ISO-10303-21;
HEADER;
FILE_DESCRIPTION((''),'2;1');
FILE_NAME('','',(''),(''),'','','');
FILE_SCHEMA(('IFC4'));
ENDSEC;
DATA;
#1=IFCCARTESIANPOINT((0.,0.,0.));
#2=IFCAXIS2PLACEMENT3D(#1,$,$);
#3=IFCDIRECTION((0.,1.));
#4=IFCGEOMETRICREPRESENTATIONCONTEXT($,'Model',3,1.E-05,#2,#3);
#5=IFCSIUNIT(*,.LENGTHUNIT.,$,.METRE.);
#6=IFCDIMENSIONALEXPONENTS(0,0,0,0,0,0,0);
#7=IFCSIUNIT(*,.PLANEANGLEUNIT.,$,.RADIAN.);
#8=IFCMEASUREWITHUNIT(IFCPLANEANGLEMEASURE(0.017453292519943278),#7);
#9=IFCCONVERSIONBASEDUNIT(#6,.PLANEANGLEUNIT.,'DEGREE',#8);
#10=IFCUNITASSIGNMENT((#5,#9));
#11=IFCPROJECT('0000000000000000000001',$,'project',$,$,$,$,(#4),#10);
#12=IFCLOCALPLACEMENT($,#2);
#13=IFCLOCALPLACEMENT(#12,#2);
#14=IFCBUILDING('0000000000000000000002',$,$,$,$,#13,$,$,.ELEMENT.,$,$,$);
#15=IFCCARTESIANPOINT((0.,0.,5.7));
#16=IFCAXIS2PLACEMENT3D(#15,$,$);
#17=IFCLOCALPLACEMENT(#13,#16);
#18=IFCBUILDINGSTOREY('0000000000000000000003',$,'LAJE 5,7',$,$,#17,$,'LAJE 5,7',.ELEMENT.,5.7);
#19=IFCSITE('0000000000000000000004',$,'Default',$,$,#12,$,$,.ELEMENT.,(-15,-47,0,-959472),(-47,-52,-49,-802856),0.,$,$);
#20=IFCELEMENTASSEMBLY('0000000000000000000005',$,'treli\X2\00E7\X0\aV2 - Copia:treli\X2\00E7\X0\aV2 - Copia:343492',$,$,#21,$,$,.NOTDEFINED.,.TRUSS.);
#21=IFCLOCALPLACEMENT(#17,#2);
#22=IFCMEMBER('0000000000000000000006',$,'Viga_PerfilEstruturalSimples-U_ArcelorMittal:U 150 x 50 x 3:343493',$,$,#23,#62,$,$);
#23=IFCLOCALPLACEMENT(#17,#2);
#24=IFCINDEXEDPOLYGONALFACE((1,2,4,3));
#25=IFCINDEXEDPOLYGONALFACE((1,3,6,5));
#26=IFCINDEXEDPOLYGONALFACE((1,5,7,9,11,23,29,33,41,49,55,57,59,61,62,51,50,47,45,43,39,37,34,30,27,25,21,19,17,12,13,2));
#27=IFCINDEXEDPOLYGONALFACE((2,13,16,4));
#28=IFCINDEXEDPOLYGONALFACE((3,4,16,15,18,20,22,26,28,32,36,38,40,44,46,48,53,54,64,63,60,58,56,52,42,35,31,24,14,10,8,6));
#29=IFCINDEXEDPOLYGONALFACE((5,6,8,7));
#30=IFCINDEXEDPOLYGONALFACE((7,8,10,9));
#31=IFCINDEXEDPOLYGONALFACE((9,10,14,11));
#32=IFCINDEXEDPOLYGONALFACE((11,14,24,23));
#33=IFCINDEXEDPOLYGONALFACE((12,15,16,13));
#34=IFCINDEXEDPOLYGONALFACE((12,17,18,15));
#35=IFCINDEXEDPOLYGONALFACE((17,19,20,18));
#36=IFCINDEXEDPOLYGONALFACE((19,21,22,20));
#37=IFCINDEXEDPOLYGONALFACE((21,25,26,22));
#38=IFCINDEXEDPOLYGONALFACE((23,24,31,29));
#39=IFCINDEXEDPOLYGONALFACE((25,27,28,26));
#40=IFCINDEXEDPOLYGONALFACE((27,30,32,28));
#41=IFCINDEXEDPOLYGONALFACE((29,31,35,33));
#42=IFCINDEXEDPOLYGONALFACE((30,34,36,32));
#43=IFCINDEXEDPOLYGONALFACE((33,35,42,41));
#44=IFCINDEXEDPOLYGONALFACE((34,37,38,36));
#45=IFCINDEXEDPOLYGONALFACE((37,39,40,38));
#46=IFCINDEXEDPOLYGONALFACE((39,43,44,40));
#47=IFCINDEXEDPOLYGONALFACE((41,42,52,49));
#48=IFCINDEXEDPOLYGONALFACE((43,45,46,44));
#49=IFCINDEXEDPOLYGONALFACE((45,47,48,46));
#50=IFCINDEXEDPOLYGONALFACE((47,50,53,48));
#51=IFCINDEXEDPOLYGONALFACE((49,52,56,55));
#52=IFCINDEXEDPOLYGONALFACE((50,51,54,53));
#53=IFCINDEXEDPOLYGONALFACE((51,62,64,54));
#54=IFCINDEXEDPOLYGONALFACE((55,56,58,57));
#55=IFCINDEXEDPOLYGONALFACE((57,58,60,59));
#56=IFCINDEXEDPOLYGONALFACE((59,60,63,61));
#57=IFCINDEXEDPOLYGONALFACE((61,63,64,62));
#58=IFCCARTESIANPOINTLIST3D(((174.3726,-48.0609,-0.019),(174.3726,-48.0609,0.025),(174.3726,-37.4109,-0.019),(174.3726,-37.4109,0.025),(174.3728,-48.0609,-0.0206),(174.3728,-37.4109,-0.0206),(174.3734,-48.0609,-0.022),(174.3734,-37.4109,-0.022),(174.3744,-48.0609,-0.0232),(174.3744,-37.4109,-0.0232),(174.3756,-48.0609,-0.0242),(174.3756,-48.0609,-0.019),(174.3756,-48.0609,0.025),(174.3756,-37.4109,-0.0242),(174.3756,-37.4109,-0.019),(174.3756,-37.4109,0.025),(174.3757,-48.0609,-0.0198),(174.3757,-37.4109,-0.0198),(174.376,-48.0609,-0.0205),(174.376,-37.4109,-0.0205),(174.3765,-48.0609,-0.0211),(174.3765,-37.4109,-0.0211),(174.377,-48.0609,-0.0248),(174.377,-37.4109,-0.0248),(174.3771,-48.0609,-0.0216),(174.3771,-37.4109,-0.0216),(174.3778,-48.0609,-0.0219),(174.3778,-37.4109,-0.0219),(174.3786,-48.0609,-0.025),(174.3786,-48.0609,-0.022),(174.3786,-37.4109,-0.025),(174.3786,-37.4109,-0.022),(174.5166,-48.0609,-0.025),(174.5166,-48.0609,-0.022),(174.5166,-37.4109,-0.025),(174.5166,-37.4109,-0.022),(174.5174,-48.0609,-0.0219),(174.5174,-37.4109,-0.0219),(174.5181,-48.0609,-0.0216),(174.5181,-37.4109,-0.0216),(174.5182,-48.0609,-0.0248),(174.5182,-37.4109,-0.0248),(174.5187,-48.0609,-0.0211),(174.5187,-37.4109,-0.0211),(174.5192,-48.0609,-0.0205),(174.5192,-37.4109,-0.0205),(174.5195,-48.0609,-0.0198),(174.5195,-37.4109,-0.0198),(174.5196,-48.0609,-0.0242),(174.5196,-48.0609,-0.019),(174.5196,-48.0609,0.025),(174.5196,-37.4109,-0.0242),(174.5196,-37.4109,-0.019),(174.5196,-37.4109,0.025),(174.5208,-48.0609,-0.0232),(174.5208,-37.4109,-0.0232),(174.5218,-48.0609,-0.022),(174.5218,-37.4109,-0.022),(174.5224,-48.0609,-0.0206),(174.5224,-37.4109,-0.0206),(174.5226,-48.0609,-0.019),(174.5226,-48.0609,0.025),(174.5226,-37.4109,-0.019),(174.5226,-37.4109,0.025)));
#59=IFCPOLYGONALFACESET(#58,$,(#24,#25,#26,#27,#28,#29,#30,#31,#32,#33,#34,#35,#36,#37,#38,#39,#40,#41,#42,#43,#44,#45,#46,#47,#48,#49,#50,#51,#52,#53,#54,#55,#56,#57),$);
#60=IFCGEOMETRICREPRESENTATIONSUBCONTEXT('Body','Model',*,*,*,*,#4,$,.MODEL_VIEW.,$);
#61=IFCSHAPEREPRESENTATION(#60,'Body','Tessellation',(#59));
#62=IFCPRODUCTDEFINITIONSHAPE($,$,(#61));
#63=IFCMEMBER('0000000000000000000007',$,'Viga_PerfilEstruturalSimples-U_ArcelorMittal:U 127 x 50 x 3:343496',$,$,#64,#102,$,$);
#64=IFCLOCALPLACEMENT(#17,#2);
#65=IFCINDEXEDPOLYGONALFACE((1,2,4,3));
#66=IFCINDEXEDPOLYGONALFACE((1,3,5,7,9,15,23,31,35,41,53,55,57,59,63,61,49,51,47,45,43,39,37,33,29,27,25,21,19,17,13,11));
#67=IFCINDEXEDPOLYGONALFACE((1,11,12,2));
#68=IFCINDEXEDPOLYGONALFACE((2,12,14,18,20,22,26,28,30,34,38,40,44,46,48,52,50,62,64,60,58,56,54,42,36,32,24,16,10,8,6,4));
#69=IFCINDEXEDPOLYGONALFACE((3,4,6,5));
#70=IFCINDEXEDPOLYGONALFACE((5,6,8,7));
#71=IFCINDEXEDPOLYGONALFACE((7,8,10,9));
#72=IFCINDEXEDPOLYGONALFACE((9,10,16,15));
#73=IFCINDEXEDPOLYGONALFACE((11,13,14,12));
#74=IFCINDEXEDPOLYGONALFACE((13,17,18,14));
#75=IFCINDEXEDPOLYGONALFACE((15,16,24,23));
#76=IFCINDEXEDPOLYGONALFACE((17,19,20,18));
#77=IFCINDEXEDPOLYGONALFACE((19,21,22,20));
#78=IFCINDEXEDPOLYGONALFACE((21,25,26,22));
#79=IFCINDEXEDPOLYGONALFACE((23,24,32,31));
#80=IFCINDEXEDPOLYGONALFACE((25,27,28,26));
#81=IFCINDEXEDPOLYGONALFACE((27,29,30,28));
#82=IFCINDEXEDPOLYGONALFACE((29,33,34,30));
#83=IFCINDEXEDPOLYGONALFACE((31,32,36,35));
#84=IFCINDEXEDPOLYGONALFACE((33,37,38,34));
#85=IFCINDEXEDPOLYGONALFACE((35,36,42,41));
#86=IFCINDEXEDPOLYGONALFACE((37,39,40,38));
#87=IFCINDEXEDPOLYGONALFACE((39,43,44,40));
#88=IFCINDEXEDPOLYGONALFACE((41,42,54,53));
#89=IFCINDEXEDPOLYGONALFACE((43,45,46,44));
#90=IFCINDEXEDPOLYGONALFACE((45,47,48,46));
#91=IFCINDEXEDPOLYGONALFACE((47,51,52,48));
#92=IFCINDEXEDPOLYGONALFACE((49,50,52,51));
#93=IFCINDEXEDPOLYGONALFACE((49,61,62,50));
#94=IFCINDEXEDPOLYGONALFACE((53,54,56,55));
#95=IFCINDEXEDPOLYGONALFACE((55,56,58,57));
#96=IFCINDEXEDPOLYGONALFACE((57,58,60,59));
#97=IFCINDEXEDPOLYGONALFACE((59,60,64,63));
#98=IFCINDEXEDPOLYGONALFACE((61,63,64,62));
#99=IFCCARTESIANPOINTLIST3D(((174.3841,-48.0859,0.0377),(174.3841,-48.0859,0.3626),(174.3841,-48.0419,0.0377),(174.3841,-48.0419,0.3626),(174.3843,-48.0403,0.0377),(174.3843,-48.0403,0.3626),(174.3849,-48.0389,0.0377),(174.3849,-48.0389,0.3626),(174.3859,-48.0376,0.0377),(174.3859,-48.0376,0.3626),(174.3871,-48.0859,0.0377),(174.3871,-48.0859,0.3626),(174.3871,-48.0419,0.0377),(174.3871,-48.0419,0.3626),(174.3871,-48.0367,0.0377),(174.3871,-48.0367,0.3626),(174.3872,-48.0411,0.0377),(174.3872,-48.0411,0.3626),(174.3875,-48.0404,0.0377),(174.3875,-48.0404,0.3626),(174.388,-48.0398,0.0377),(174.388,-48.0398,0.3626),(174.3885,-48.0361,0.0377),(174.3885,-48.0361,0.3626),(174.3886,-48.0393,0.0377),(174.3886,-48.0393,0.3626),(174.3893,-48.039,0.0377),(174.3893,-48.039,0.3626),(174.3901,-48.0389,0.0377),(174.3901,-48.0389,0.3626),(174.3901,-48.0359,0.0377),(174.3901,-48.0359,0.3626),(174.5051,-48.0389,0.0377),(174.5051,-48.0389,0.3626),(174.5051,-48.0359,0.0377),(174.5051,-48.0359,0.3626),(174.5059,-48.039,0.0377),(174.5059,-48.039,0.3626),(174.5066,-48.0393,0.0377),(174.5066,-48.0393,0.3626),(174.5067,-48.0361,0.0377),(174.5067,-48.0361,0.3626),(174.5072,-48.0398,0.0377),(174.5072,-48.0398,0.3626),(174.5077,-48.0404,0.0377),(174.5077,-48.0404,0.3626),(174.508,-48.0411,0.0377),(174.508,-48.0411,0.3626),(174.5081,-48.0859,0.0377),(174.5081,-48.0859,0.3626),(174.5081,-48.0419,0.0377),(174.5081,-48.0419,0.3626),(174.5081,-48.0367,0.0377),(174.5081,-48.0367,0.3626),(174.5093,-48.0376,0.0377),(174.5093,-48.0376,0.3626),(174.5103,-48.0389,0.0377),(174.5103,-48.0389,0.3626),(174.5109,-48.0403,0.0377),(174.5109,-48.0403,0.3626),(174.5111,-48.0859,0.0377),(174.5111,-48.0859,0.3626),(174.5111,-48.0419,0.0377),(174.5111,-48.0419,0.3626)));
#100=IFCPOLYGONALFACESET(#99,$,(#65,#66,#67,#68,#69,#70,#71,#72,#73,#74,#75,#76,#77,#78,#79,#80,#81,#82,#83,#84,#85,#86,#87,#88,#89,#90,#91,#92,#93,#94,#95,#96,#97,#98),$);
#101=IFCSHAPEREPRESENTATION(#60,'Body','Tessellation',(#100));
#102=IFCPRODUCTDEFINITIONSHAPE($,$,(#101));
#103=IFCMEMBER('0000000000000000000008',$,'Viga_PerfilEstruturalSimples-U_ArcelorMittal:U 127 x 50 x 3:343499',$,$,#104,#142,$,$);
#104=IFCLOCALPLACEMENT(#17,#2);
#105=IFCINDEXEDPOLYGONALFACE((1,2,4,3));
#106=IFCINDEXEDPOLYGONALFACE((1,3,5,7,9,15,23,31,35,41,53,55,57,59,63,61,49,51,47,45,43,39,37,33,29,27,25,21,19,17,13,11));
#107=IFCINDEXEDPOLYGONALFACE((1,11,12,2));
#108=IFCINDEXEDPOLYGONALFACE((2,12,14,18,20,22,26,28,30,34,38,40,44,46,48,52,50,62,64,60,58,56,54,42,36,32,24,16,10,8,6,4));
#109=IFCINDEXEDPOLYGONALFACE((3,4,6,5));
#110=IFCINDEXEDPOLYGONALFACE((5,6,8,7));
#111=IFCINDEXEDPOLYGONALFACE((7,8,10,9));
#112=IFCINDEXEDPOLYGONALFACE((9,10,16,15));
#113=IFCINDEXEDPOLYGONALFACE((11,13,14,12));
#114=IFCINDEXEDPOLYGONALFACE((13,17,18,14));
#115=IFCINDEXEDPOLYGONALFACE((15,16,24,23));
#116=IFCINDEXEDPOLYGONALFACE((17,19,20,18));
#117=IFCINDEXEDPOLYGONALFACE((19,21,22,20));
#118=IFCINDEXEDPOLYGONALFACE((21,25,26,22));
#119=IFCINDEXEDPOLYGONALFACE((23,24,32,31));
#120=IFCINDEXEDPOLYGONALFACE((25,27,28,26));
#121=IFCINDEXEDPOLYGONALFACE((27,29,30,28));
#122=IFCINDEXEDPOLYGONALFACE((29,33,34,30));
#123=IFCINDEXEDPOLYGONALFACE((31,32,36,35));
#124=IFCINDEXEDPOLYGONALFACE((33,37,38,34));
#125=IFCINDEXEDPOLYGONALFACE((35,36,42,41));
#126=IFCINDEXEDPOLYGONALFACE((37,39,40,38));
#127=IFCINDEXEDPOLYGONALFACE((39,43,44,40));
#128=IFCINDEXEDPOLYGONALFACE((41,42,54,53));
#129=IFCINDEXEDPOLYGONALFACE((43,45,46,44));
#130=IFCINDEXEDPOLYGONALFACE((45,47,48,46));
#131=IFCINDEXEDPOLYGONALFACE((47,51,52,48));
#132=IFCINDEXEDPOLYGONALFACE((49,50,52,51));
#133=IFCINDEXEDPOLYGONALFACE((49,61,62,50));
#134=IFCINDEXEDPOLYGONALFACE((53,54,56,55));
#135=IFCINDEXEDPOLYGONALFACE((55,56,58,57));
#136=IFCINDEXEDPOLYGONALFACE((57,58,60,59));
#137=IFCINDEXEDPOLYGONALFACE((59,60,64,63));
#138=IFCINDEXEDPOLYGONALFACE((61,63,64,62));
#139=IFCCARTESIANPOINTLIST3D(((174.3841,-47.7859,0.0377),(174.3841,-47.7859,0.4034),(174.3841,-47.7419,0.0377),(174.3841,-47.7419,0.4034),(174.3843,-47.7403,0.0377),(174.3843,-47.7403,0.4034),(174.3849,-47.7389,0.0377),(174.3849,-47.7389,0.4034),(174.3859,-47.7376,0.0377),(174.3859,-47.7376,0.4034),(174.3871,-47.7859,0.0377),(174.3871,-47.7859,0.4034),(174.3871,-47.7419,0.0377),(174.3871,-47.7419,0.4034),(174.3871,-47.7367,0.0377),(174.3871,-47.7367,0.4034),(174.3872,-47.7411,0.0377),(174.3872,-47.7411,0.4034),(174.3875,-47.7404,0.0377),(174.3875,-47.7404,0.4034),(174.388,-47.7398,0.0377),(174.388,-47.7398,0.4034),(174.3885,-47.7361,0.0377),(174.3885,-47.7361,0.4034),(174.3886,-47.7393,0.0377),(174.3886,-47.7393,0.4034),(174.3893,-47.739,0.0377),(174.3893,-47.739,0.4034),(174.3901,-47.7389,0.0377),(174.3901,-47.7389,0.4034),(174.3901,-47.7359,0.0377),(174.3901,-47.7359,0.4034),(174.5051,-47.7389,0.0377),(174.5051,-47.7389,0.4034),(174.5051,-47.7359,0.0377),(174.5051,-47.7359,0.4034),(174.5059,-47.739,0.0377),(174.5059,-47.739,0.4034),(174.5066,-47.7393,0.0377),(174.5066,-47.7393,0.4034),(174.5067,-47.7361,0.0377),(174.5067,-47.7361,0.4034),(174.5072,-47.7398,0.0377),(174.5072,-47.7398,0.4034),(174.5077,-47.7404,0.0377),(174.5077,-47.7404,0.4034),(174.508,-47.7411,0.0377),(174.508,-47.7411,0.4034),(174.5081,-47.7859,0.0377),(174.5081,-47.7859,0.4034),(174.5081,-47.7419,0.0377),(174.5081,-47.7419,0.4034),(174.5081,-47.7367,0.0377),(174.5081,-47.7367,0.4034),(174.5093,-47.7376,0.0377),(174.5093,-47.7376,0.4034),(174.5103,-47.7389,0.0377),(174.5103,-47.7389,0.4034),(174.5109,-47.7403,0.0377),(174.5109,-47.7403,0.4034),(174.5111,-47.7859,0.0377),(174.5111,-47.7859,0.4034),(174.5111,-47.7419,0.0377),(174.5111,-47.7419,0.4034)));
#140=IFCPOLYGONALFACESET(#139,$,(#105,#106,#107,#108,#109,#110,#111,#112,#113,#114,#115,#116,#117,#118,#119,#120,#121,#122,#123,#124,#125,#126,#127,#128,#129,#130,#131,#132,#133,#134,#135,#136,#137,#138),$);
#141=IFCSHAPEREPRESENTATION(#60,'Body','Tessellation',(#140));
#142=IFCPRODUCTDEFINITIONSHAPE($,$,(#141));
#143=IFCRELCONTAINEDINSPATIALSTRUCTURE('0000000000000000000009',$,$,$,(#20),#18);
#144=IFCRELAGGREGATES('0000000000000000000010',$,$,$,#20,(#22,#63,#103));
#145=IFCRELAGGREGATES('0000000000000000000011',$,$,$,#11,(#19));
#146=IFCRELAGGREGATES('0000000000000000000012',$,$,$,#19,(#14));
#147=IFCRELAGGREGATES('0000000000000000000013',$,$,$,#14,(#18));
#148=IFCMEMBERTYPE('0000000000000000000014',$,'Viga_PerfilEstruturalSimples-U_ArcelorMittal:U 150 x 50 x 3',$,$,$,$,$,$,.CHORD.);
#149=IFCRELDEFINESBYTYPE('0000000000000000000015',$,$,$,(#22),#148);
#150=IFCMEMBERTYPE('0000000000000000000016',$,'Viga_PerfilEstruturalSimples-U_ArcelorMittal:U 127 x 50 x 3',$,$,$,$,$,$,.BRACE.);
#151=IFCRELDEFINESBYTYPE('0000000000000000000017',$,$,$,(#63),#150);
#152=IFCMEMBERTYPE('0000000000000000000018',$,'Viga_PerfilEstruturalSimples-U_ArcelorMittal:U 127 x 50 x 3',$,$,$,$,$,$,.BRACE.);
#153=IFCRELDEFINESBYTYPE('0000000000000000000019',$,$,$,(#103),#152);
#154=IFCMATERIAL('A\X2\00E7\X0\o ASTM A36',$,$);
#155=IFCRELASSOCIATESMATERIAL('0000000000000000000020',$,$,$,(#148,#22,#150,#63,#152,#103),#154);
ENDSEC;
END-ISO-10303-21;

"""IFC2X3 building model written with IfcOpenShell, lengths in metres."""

from ifc_helpers import new_model, entity, si_unit, converted_unit, direction, frame, frame_2d, origin, place, context, subcontext, project, spatial, polyline, circle_curve, parameter, trimmed, segment, composite_curve, outline, extrude, source, transform, mapped, material, type_object, type_shapes, element, aggregate, save


model = new_model("IFC2X3")

# Units and contexts
model_context = context("Model", 3, precision=1e-05, world=origin(), true_north=direction((0.0, 1.0)))
body_context = subcontext(model_context, "Body", "Model", "MODEL_VIEW")
ifc_project = project(units=[si_unit("LENGTHUNIT", "METRE"), converted_unit("PLANEANGLEUNIT", "DEGREE", entity("IfcPlaneAngleMeasure", 0.017453292519943278), si_unit("PLANEANGLEUNIT", "RADIAN"), dimensions=[0, 0, 0, 0, 0, 0, 0])], contexts=[model_context])

# Site, building, storey
site_placement = place(None, origin())
site = spatial("IfcSite", under=ifc_project, at=site_placement, Name="Default", CompositionType="ELEMENT", RefLatitude=(-15, -47, 0, -959472), RefLongitude=(-47, -52, -49, -802856), RefElevation=0.0)
building_placement = place(site_placement, origin())
building = spatial("IfcBuilding", under=site, at=building_placement, CompositionType="ELEMENT")
storey_placement = place(building_placement, frame((0.0, 0.0, 5.7)))
storey = spatial("IfcBuildingStorey", under=building, at=storey_placement, Name="LAJE 5,7", LongName="LAJE 5,7", CompositionType="ELEMENT", Elevation=5.7)

# Element assembly, members
assembly_1_placement = place(storey_placement, origin())
assembly_1 = element("IfcElementAssembly", 1, at=assembly_1_placement, inside=storey, Name="treliçaV2 - Copia:treliçaV2 - Copia:343492", AssemblyPlace="NOTDEFINED", PredefinedType="TRUSS")
ifc_material = material(Name="Aço ASTM A36")
member_type_1 = type_object("IfcMemberType", Name="Viga_PerfilEstruturalSimples-U_ArcelorMittal:U 150 x 50 x 3", PredefinedType="CHORD", material=ifc_material)
shared_shape_1 = source(origin(), body_context, "Body", "SweptSolid", [
    extrude(outline(composite_curve([segment(polyline([(-0.069, -0.0192), (0.069, -0.0192)]), True, "CONTINUOUS"), segment(trimmed(circle_curve(frame_2d((0.069, -0.0132), x_axis=(0.0, 1.0)), 0.006), [parameter(180.0)], [parameter(270.0)], True, "PARAMETER"), True, "CONTINUOUS"), segment(polyline([(0.075, -0.0132), (0.075, 0.0308)]), True, "CONTINUOUS"), segment(polyline([(0.075, 0.0308), (0.072, 0.0308)]), True, "CONTINUOUS"), segment(polyline([(0.072, 0.0308), (0.072, -0.0132)]), True, "CONTINUOUS"), segment(trimmed(circle_curve(frame_2d((0.069, -0.0132), x_axis=(0.0, 1.0)), 0.003), [parameter(180.0)], [parameter(270.0)], True, "PARAMETER"), False, "CONTINUOUS"), segment(polyline([(0.069, -0.0162), (-0.069, -0.0162)]), True, "CONTINUOUS"), segment(trimmed(circle_curve(frame_2d((-0.069, -0.0132), x_axis=(0.0, 1.0)), 0.003), [parameter(90.0)], [parameter(180.0)], True, "PARAMETER"), False, "CONTINUOUS"), segment(polyline([(-0.072, -0.0132), (-0.072, 0.0308)]), True, "CONTINUOUS"), segment(polyline([(-0.072, 0.0308), (-0.075, 0.0308)]), True, "CONTINUOUS"), segment(polyline([(-0.075, 0.0308), (-0.075, -0.0132)]), True, "CONTINUOUS"), segment(trimmed(circle_curve(frame_2d((-0.069, -0.0132), x_axis=(0.0, 1.0)), 0.006), [parameter(90.0)], [parameter(180.0)], True, "PARAMETER"), True, "CONTINUOUS")], self_intersect=False)), frame((-5.325, -0.0058, 0.0), z_axis=(1.0, 0.0, 0.0), x_axis=(0.0, 0.0, -1.0)), (0.0, 0.0, 1.0), 10.65),
])
type_shapes(member_type_1, [shared_shape_1])
member_1_placement = place(assembly_1_placement, frame((174.4476, -42.7359, 0.0), z_axis=(1.0, 0.0, 0.0), x_axis=(0.0, 1.0, 0.0)))
member_1 = element("IfcMember", 2, at=member_1_placement, type_object=member_type_1, material=ifc_material, Name="Viga_PerfilEstruturalSimples-U_ArcelorMittal:U 150 x 50 x 3:343493", context=body_context, shape_type="MappedRepresentation", body=[
    mapped(shared_shape_1, transform((0.0, 0.0, 0.0), scale=1.0)),
])
member_type_2 = type_object("IfcMemberType", Name="Viga_PerfilEstruturalSimples-U_ArcelorMittal:U 127 x 50 x 3", PredefinedType="BRACE", material=ifc_material)
shared_shape_2 = source(origin(), body_context, "Body", "SweptSolid", [
    extrude(outline(composite_curve([segment(polyline([(-0.0575, -0.0192), (0.0575, -0.0192)]), True, "CONTINUOUS"), segment(trimmed(circle_curve(frame_2d((0.0575, -0.0132), x_axis=(0.0, 1.0)), 0.006), [parameter(180.0)], [parameter(270.0)], True, "PARAMETER"), True, "CONTINUOUS"), segment(polyline([(0.0635, -0.0132), (0.0635, 0.0308)]), True, "CONTINUOUS"), segment(polyline([(0.0635, 0.0308), (0.0605, 0.0308)]), True, "CONTINUOUS"), segment(polyline([(0.0605, 0.0308), (0.0605, -0.0132)]), True, "CONTINUOUS"), segment(trimmed(circle_curve(frame_2d((0.0575, -0.0132), x_axis=(0.0, 1.0)), 0.003), [parameter(180.0)], [parameter(270.0)], True, "PARAMETER"), False, "CONTINUOUS"), segment(polyline([(0.0575, -0.0162), (-0.0575, -0.0162)]), True, "CONTINUOUS"), segment(trimmed(circle_curve(frame_2d((-0.0575, -0.0132), x_axis=(0.0, 1.0)), 0.003), [parameter(90.0)], [parameter(180.0)], True, "PARAMETER"), False, "CONTINUOUS"), segment(polyline([(-0.0605, -0.0132), (-0.0605, 0.0308)]), True, "CONTINUOUS"), segment(polyline([(-0.0605, 0.0308), (-0.0635, 0.0308)]), True, "CONTINUOUS"), segment(polyline([(-0.0635, 0.0308), (-0.0635, -0.0132)]), True, "CONTINUOUS"), segment(trimmed(circle_curve(frame_2d((-0.0575, -0.0132), x_axis=(0.0, 1.0)), 0.006), [parameter(90.0)], [parameter(180.0)], True, "PARAMETER"), True, "CONTINUOUS")], self_intersect=False)), frame((-0.1623, -0.0058, 0.0), z_axis=(1.0, 0.0, 0.0), x_axis=(0.0, 0.0, -1.0)), (0.0, 0.0, 1.0), 0.3249),
])
type_shapes(member_type_2, [shared_shape_2])
member_2_placement = place(assembly_1_placement, frame((174.4476, -48.0609, 0.2), z_axis=(1.0, 0.0, 0.0), x_axis=(0.0, 0.0, 1.0)))
member_2 = element("IfcMember", 3, at=member_2_placement, type_object=member_type_2, material=ifc_material, Name="Viga_PerfilEstruturalSimples-U_ArcelorMittal:U 127 x 50 x 3:343496", context=body_context, shape_type="MappedRepresentation", body=[
    mapped(shared_shape_2, transform((0.0, 0.0, 0.0), scale=1.0)),
])
member_type_3 = type_object("IfcMemberType", Name="Viga_PerfilEstruturalSimples-U_ArcelorMittal:U 127 x 50 x 3", PredefinedType="BRACE", material=ifc_material)
shared_shape_3 = source(origin(), body_context, "Body", "SweptSolid", [
    extrude(outline(composite_curve([segment(polyline([(-0.0575, -0.0192), (0.0575, -0.0192)]), True, "CONTINUOUS"), segment(trimmed(circle_curve(frame_2d((0.0575, -0.0132), x_axis=(0.0, 1.0)), 0.006), [parameter(180.0)], [parameter(270.0)], True, "PARAMETER"), True, "CONTINUOUS"), segment(polyline([(0.0635, -0.0132), (0.0635, 0.0308)]), True, "CONTINUOUS"), segment(polyline([(0.0635, 0.0308), (0.0605, 0.0308)]), True, "CONTINUOUS"), segment(polyline([(0.0605, 0.0308), (0.0605, -0.0132)]), True, "CONTINUOUS"), segment(trimmed(circle_curve(frame_2d((0.0575, -0.0132), x_axis=(0.0, 1.0)), 0.003), [parameter(180.0)], [parameter(270.0)], True, "PARAMETER"), False, "CONTINUOUS"), segment(polyline([(0.0575, -0.0162), (-0.0575, -0.0162)]), True, "CONTINUOUS"), segment(trimmed(circle_curve(frame_2d((-0.0575, -0.0132), x_axis=(0.0, 1.0)), 0.003), [parameter(90.0)], [parameter(180.0)], True, "PARAMETER"), False, "CONTINUOUS"), segment(polyline([(-0.0605, -0.0132), (-0.0605, 0.0308)]), True, "CONTINUOUS"), segment(polyline([(-0.0605, 0.0308), (-0.0635, 0.0308)]), True, "CONTINUOUS"), segment(polyline([(-0.0635, 0.0308), (-0.0635, -0.0132)]), True, "CONTINUOUS"), segment(trimmed(circle_curve(frame_2d((-0.0575, -0.0132), x_axis=(0.0, 1.0)), 0.006), [parameter(90.0)], [parameter(180.0)], True, "PARAMETER"), True, "CONTINUOUS")], self_intersect=False)), frame((-0.1849, -0.0058, 0.0), z_axis=(1.0, 0.0, 0.0), x_axis=(0.0, 0.0, -1.0)), (0.0, 0.0, 1.0), 0.3657),
])
type_shapes(member_type_3, [shared_shape_3])
member_3_placement = place(assembly_1_placement, frame((174.4476, -47.7609, 0.2226), z_axis=(1.0, 0.0, 0.0), x_axis=(0.0, 0.0, 1.0)))
member_3 = element("IfcMember", 4, at=member_3_placement, type_object=member_type_3, material=ifc_material, Name="Viga_PerfilEstruturalSimples-U_ArcelorMittal:U 127 x 50 x 3:343499", context=body_context, shape_type="MappedRepresentation", body=[
    mapped(shared_shape_3, transform((0.0, 0.0, 0.0), scale=1.0)),
])

aggregate(assembly_1, [member_1, member_2, member_3])

save(model, "model.ifc")
